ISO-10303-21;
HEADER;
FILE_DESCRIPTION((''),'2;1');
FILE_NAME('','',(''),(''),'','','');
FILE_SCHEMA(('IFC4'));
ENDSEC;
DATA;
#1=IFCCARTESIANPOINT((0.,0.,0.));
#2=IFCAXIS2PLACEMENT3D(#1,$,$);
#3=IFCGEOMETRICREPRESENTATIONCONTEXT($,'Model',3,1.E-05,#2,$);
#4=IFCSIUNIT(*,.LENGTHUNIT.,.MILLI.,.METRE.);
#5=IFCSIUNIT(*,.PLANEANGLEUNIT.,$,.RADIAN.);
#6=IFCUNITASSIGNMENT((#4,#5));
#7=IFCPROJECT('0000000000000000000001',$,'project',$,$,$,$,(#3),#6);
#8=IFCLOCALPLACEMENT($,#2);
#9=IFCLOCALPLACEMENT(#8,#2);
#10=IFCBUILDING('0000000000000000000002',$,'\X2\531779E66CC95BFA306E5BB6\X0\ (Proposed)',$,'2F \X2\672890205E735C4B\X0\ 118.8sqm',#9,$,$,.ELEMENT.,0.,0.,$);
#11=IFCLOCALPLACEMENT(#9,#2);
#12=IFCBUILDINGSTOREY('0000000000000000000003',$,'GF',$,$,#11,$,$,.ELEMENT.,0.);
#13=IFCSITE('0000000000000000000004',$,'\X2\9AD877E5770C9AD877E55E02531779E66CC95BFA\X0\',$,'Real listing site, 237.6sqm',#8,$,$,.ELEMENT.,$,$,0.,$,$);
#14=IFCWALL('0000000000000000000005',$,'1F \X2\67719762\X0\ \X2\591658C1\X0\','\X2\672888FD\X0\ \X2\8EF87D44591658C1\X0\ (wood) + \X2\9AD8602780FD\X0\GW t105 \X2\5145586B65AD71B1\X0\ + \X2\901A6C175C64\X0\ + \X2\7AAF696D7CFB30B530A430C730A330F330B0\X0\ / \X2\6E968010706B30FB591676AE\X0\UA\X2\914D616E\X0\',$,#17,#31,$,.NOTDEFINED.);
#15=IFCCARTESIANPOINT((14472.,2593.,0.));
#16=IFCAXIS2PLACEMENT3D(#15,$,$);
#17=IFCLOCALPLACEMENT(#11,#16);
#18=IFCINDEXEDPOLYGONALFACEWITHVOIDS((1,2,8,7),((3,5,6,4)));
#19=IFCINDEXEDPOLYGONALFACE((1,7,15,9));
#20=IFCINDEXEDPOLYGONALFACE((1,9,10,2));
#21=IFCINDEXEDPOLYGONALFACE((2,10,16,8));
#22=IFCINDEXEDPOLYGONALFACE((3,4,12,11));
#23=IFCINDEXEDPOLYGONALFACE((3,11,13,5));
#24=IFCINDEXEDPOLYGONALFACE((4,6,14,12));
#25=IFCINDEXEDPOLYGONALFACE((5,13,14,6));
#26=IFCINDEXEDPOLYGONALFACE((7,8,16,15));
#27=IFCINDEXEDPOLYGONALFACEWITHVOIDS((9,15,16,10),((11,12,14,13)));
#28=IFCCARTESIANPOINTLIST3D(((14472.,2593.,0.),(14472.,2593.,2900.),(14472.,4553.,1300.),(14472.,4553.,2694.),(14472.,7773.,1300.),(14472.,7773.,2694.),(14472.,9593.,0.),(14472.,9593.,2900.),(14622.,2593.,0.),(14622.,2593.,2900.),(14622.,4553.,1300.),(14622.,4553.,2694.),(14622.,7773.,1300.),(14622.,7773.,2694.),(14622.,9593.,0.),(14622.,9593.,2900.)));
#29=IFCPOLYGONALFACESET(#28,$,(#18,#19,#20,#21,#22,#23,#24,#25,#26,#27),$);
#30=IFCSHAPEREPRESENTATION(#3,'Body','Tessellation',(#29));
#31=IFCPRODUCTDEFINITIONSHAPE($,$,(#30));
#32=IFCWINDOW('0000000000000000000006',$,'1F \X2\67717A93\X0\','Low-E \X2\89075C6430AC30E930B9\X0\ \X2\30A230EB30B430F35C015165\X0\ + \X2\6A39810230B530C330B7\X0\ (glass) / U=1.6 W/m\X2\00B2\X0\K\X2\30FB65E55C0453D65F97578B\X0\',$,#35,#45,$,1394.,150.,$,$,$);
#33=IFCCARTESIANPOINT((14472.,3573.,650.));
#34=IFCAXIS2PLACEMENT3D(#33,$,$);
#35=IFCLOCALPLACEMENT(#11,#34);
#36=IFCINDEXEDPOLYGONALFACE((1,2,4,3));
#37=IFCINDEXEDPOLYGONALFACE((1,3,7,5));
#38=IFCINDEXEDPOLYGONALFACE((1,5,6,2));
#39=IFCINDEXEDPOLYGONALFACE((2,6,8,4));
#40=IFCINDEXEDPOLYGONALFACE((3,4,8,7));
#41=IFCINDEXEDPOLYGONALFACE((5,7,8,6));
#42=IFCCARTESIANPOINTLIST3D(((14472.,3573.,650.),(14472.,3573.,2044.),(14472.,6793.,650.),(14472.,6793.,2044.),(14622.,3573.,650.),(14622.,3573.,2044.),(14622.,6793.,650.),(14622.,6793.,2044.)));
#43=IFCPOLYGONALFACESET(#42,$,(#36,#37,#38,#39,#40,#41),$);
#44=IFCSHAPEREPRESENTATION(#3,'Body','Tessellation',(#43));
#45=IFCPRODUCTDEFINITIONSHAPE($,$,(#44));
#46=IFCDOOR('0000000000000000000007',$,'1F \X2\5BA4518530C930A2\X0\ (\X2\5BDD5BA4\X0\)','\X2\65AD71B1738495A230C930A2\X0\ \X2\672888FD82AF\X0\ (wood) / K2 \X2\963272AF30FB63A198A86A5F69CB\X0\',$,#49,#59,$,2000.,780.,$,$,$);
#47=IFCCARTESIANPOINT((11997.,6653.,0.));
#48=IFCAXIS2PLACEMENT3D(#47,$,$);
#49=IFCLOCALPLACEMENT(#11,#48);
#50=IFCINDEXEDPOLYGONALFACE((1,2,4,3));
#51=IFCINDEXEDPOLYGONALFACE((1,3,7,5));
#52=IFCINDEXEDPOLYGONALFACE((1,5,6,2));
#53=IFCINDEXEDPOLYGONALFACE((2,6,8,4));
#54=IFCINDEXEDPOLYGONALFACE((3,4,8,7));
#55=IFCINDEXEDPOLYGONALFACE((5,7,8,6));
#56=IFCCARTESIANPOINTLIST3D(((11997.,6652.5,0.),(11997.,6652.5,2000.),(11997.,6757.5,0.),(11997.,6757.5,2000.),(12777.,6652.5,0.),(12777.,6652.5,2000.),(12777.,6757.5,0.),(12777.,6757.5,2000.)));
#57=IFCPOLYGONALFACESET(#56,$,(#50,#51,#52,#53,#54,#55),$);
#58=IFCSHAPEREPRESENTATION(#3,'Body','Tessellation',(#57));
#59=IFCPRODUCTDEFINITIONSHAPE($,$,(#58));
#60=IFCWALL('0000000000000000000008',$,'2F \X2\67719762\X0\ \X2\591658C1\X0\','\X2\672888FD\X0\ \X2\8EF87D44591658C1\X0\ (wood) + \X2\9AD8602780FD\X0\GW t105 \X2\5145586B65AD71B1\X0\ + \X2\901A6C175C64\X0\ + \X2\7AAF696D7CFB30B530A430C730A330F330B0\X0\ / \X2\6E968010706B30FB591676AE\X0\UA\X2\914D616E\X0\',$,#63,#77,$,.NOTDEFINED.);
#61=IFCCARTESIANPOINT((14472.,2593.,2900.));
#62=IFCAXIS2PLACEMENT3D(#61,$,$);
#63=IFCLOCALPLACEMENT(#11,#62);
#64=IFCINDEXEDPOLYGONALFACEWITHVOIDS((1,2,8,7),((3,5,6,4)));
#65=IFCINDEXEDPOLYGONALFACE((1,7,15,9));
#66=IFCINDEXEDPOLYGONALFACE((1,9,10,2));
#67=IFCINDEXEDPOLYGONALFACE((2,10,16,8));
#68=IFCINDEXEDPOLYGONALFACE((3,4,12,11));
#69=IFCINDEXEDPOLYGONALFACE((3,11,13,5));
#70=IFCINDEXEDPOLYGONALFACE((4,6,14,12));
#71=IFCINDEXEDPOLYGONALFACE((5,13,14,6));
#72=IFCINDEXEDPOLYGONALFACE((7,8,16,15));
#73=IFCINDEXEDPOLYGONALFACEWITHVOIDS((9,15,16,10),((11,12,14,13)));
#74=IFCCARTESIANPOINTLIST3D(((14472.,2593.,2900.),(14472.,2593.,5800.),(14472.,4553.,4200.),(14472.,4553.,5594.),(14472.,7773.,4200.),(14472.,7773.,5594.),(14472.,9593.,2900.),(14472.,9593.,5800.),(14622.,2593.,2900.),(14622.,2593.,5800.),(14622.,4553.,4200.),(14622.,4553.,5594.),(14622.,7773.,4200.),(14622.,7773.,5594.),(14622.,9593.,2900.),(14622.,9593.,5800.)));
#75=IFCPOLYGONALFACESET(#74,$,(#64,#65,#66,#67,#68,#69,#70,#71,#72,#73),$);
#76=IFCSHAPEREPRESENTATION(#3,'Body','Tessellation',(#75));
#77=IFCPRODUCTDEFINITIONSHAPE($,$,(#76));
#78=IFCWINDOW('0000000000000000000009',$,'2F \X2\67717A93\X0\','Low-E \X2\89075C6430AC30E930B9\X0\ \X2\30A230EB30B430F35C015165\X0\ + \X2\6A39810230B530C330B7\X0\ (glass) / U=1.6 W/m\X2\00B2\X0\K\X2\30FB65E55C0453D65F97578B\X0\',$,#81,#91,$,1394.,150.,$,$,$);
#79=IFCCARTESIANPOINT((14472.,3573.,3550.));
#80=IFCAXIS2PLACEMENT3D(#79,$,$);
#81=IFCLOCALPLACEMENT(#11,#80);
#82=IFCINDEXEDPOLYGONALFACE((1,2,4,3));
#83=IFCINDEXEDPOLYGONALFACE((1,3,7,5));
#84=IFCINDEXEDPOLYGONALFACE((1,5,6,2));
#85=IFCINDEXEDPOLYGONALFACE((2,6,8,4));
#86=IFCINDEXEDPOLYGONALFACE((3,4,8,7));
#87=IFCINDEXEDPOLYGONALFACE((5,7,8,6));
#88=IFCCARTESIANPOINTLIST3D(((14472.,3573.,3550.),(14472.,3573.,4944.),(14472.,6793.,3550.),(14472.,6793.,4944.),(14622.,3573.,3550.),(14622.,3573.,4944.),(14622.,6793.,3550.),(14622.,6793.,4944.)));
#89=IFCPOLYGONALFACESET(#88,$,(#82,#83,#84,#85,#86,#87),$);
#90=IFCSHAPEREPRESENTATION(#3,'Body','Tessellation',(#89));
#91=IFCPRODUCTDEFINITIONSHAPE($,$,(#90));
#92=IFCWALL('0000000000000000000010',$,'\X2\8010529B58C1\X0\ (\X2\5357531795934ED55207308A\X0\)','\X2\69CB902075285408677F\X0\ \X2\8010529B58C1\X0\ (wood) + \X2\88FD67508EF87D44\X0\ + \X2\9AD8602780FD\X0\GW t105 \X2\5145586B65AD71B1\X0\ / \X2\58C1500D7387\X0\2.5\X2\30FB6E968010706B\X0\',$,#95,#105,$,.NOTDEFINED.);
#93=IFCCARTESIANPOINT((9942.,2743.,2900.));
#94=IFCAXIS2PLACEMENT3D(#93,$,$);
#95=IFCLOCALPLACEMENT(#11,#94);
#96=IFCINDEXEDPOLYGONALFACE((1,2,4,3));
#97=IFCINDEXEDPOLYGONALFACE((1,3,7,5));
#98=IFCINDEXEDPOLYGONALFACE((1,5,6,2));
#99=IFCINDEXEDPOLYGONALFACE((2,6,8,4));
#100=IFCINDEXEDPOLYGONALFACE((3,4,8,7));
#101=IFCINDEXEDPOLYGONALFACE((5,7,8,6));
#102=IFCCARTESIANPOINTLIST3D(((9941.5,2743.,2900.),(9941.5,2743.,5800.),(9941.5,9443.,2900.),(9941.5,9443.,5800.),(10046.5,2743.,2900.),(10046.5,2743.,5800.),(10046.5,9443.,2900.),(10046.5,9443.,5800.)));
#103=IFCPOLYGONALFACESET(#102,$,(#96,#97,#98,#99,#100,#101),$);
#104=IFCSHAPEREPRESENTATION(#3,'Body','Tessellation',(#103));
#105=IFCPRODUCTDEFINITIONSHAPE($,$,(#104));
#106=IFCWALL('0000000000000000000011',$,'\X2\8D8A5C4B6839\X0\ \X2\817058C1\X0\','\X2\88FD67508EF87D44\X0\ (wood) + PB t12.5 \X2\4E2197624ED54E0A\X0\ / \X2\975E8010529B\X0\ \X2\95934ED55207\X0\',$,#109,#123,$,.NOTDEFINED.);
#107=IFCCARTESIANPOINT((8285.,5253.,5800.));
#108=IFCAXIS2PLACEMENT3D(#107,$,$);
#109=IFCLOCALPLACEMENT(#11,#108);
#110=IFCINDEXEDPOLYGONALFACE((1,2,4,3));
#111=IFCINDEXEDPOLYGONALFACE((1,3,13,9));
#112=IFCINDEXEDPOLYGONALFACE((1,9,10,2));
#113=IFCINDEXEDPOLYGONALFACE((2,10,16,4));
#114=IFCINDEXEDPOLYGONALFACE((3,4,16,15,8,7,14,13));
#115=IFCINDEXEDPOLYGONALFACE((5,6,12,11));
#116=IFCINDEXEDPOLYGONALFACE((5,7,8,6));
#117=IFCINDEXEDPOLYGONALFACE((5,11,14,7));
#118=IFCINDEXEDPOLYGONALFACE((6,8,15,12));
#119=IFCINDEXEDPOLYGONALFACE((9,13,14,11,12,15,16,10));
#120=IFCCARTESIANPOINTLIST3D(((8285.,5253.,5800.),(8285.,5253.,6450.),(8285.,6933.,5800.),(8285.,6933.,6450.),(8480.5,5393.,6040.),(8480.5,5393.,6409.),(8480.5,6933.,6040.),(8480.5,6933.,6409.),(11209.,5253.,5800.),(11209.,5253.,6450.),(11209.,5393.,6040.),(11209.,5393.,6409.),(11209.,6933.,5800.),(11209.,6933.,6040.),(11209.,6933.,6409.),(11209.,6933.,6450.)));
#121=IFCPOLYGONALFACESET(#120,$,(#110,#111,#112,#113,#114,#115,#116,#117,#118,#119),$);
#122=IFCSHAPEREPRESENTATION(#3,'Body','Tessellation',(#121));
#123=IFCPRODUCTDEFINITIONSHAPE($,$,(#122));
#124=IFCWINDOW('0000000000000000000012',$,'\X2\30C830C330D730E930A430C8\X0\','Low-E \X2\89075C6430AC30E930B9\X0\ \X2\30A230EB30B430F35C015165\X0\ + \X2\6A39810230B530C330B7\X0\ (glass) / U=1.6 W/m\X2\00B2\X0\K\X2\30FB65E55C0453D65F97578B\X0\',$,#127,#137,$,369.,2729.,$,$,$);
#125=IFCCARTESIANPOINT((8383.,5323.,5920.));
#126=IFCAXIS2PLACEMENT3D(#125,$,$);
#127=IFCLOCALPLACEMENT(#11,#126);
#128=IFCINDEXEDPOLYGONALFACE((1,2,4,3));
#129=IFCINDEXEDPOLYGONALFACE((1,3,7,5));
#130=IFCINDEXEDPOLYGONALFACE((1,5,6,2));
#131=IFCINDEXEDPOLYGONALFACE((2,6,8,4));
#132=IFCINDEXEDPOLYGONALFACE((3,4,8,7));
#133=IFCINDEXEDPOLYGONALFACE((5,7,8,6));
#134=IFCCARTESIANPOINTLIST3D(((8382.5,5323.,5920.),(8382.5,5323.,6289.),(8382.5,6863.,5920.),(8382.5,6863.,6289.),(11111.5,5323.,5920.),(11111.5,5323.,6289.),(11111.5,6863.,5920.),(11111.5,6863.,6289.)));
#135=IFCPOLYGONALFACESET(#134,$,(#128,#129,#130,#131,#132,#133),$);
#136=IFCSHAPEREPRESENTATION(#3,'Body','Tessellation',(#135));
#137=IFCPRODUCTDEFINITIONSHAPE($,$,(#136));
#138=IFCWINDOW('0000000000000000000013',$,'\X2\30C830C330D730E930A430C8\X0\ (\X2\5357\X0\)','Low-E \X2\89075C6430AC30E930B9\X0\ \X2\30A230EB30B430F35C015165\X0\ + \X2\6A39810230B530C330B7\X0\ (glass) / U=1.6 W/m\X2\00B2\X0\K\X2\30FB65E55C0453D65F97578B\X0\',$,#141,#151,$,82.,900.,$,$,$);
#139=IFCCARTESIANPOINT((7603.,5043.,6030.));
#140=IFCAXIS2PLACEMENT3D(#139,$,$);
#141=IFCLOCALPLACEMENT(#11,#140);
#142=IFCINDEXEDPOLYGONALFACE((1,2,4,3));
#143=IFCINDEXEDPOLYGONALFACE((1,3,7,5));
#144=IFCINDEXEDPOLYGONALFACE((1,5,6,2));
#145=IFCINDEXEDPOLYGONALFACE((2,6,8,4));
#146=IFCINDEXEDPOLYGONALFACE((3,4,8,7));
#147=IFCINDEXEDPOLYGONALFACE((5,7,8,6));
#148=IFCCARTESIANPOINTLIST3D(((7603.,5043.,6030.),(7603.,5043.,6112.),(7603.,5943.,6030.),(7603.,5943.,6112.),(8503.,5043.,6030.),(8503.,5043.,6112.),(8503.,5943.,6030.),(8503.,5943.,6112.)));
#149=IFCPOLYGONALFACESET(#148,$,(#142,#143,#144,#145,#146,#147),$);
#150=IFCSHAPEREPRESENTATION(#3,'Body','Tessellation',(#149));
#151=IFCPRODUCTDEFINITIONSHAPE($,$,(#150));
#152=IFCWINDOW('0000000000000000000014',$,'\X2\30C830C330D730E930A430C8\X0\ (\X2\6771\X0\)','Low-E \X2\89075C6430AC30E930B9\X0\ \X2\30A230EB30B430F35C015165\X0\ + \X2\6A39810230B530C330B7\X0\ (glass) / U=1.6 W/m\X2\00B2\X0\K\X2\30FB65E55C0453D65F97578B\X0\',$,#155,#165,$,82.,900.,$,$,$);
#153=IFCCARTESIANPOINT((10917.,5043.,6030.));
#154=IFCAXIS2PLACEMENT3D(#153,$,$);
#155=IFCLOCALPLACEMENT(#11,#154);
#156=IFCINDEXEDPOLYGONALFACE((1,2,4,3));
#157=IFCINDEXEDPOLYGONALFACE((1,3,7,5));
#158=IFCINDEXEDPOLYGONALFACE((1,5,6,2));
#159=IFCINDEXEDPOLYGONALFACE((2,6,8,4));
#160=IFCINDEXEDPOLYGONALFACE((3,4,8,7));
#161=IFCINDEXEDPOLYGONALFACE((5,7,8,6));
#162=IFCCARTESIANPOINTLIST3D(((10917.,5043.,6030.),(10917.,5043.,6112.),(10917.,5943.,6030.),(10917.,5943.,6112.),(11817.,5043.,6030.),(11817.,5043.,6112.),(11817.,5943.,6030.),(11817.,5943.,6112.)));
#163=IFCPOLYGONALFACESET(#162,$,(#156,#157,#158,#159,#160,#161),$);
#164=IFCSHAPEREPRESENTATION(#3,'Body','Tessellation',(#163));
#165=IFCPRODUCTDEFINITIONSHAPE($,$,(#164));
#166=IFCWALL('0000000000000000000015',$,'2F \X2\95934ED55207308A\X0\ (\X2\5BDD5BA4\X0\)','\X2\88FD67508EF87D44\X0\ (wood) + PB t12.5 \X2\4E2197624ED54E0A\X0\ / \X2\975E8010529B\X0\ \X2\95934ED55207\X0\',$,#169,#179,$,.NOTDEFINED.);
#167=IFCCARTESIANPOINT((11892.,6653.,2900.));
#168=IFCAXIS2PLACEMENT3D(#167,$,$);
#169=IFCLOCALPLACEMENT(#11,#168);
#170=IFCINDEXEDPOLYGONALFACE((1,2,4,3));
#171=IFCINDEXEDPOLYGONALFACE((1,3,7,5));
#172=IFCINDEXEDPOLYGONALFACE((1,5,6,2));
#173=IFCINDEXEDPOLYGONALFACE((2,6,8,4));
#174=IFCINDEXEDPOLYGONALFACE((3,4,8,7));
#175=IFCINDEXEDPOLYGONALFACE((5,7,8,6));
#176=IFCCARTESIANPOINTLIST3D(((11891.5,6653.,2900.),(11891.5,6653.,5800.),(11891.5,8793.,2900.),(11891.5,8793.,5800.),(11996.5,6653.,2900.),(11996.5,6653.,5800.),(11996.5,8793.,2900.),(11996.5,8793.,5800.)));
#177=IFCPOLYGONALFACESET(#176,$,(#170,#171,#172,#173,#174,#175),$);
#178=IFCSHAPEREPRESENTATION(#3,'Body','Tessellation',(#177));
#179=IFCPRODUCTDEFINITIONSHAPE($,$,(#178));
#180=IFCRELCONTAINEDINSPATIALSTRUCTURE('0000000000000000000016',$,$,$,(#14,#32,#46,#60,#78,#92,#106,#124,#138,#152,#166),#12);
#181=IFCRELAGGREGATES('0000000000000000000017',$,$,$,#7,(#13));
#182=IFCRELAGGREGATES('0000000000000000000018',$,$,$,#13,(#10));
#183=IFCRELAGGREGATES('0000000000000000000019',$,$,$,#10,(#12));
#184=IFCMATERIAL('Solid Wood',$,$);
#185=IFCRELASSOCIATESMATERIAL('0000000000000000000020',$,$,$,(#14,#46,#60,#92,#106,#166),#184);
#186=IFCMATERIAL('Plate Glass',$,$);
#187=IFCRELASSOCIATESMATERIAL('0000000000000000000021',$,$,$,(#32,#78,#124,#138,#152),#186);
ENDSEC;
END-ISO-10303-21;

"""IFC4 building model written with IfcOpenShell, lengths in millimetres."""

from ifc_helpers import new_model, si_unit, frame, frame_2d, origin, place, context, project, spatial, rectangle, extrude, material, element, fill, save


model = new_model("IFC4")

# Units and contexts
model_context = context("Model", 3, precision=1e-05, world=origin())
ifc_project = project(units=[si_unit("LENGTHUNIT", "METRE", prefix="MILLI"), si_unit("PLANEANGLEUNIT", "RADIAN")], contexts=[model_context])

# Site, building, storey
site_placement = place(None, origin())
site = spatial("IfcSite", under=ifc_project, at=site_placement, Name="高知県高知市北秦泉寺", ObjectType="Real listing site, 237.6sqm", CompositionType="ELEMENT", RefElevation=0.0)
building_placement = place(site_placement, origin())
building = spatial("IfcBuilding", under=site, at=building_placement, Name="北秦泉寺の家 (Proposed)", ObjectType="2F 木造平屋 118.8sqm", CompositionType="ELEMENT", ElevationOfRefHeight=0.0, ElevationOfTerrain=0.0)
storey_placement = place(building_placement, origin())
storey = spatial("IfcBuildingStorey", under=building, at=storey_placement, Name="GF", CompositionType="ELEMENT", Elevation=0.0)

# Wall, opening, window
ifc_material_1 = material(Name="Solid Wood")
wall_1_placement = place(storey_placement, frame((14472.0, 2593.0, 0.0)))
wall_1 = element("IfcWall", 1, at=wall_1_placement, inside=storey, material=ifc_material_1, Name="1F 東面 外壁", Description="木製 軸組外壁 (wood) + 高性能GW t105 充填断熱 + 通気層 + 窯業系サイディング / 準耐火・外皮UA配慮", PredefinedType="NOTDEFINED", context=model_context, shape_type="SweptSolid", body=[
    extrude(rectangle(XDim=150.0, YDim=7000.0, at=frame_2d((75.0, 3500.0))), frame((14472.0, 2593.0, 0.0)), (0.0, 0.0, 1.0), 2900.0),
])
opening_1_placement = place(storey_placement, frame((14472.0, 3573.0, 650.0)))
opening_1 = element("IfcOpeningElement", 2, at=opening_1_placement, cuts=wall_1, PredefinedType="NOTDEFINED", context=model_context, shape_type="SweptSolid", body=[
    extrude(rectangle(XDim=150.0, YDim=3220.0, at=frame_2d((75.0, 1610.0))), frame((14472.0, 3573.0, 650.0)), (0.0, 0.0, 1.0), 1394.0),
])
ifc_material_2 = material(Name="Plate Glass")
window_1_placement = place(storey_placement, frame((14472.0, 3573.0, 650.0)))
window_1 = element("IfcWindow", 3, at=window_1_placement, inside=storey, material=ifc_material_2, Name="1F 東窓", Description="Low-E 複層ガラス アルゴン封入 + 樹脂サッシ (glass) / U=1.6 W/m²K・日射取得型", OverallHeight=1394.0, OverallWidth=150.0, context=model_context, shape_type="SweptSolid", body=[
    extrude(rectangle(XDim=150.0, YDim=3220.0, at=frame_2d((75.0, 1610.0))), frame((14472.0, 3573.0, 650.0)), (0.0, 0.0, 1.0), 1394.0),
])
fill(opening_1, window_1)

# Door
door_1_placement = place(storey_placement, frame((11997.0, 6653.0, 0.0)))
element("IfcDoor", 4, at=door_1_placement, inside=storey, material=ifc_material_1, Name="1F 室内ドア (寝室)", Description="断熱玄関ドア 木製芯 (wood) / K2 防犯・採風機構", OverallHeight=2000.0, OverallWidth=780.0, context=model_context, shape_type="SweptSolid", body=[
    extrude(rectangle(XDim=780.0, YDim=105.0, at=frame_2d((390.0, 52.0))), frame((11997.0, 6653.0, 0.0)), (0.0, 0.0, 1.0), 2000.0),
])

# Wall, opening, window
wall_2_placement = place(storey_placement, frame((14472.0, 2593.0, 2900.0)))
wall_2 = element("IfcWall", 5, at=wall_2_placement, inside=storey, material=ifc_material_1, Name="2F 東面 外壁", Description="木製 軸組外壁 (wood) + 高性能GW t105 充填断熱 + 通気層 + 窯業系サイディング / 準耐火・外皮UA配慮", PredefinedType="NOTDEFINED", context=model_context, shape_type="SweptSolid", body=[
    extrude(rectangle(XDim=150.0, YDim=7000.0, at=frame_2d((75.0, 3500.0))), frame((14472.0, 2593.0, 2900.0)), (0.0, 0.0, 1.0), 2900.0),
])
opening_2_placement = place(storey_placement, frame((14472.0, 3573.0, 3550.0)))
opening_2 = element("IfcOpeningElement", 6, at=opening_2_placement, cuts=wall_2, PredefinedType="NOTDEFINED", context=model_context, shape_type="SweptSolid", body=[
    extrude(rectangle(XDim=150.0, YDim=3220.0, at=frame_2d((75.0, 1610.0))), frame((14472.0, 3573.0, 3550.0)), (0.0, 0.0, 1.0), 1394.0),
])
window_2_placement = place(storey_placement, frame((14472.0, 3573.0, 3550.0)))
window_2 = element("IfcWindow", 7, at=window_2_placement, inside=storey, material=ifc_material_2, Name="2F 東窓", Description="Low-E 複層ガラス アルゴン封入 + 樹脂サッシ (glass) / U=1.6 W/m²K・日射取得型", OverallHeight=1394.0, OverallWidth=150.0, context=model_context, shape_type="SweptSolid", body=[
    extrude(rectangle(XDim=150.0, YDim=3220.0, at=frame_2d((75.0, 1610.0))), frame((14472.0, 3573.0, 3550.0)), (0.0, 0.0, 1.0), 1394.0),
])
fill(opening_2, window_2)

# Wall
wall_3_placement = place(storey_placement, frame((9942.0, 2743.0, 2900.0)))
element("IfcWall", 8, at=wall_3_placement, inside=storey, material=ifc_material_1, Name="耐力壁 (南北間仕切り)", Description="構造用合板 耐力壁 (wood) + 製材軸組 + 高性能GW t105 充填断熱 / 壁倍率2.5・準耐火", PredefinedType="NOTDEFINED", context=model_context, shape_type="SweptSolid", body=[
    extrude(rectangle(XDim=105.0, YDim=6700.0, at=frame_2d((52.0, 3350.0))), frame((9942.0, 2743.0, 2900.0)), (0.0, 0.0, 1.0), 2900.0),
])

# Wall, openings, windows
wall_4_placement = place(storey_placement, frame((8285.0, 5253.0, 5800.0)))
wall_4 = element("IfcWall", 9, at=wall_4_placement, inside=storey, material=ifc_material_1, Name="越屋根 腰壁", Description="製材軸組 (wood) + PB t12.5 両面仕上 / 非耐力 間仕切", PredefinedType="NOTDEFINED", context=model_context, shape_type="SweptSolid", body=[
    extrude(rectangle(XDim=2924.0, YDim=1680.0, at=frame_2d((1462.0, 840.0))), frame((8285.0, 5253.0, 5800.0)), (0.0, 0.0, 1.0), 650.0),
])
opening_3_placement = place(storey_placement, frame((8383.0, 5323.0, 5920.0)))
opening_3 = element("IfcOpeningElement", 10, at=opening_3_placement, cuts=wall_4, PredefinedType="NOTDEFINED", context=model_context, shape_type="SweptSolid", body=[
    extrude(rectangle(XDim=2729.0, YDim=1540.0, at=frame_2d((1364.0, 770.0))), frame((8383.0, 5323.0, 5920.0)), (0.0, 0.0, 1.0), 369.0),
])
opening_4_placement = place(storey_placement, frame((7603.0, 5043.0, 6030.0)))
opening_4 = element("IfcOpeningElement", 11, at=opening_4_placement, cuts=wall_4, PredefinedType="NOTDEFINED", context=model_context, shape_type="SweptSolid", body=[
    extrude(rectangle(XDim=900.0, YDim=900.0, at=frame_2d((450.0, 450.0))), frame((7603.0, 5043.0, 6030.0)), (0.0, 0.0, 1.0), 82.0),
])
opening_5_placement = place(storey_placement, frame((10917.0, 5043.0, 6030.0)))
opening_5 = element("IfcOpeningElement", 12, at=opening_5_placement, cuts=wall_4, PredefinedType="NOTDEFINED", context=model_context, shape_type="SweptSolid", body=[
    extrude(rectangle(XDim=900.0, YDim=900.0, at=frame_2d((450.0, 450.0))), frame((10917.0, 5043.0, 6030.0)), (0.0, 0.0, 1.0), 82.0),
])
window_3_placement = place(storey_placement, frame((8383.0, 5323.0, 5920.0)))
window_3 = element("IfcWindow", 13, at=window_3_placement, inside=storey, material=ifc_material_2, Name="トップライト", Description="Low-E 複層ガラス アルゴン封入 + 樹脂サッシ (glass) / U=1.6 W/m²K・日射取得型", OverallHeight=369.0, OverallWidth=2729.0, context=model_context, shape_type="SweptSolid", body=[
    extrude(rectangle(XDim=2729.0, YDim=1540.0, at=frame_2d((1364.0, 770.0))), frame((8383.0, 5323.0, 5920.0)), (0.0, 0.0, 1.0), 369.0),
])
fill(opening_3, window_3)
window_4_placement = place(storey_placement, frame((7603.0, 5043.0, 6030.0)))
window_4 = element("IfcWindow", 14, at=window_4_placement, inside=storey, material=ifc_material_2, Name="トップライト (南)", Description="Low-E 複層ガラス アルゴン封入 + 樹脂サッシ (glass) / U=1.6 W/m²K・日射取得型", OverallHeight=82.0, OverallWidth=900.0, context=model_context, shape_type="SweptSolid", body=[
    extrude(rectangle(XDim=900.0, YDim=900.0, at=frame_2d((450.0, 450.0))), frame((7603.0, 5043.0, 6030.0)), (0.0, 0.0, 1.0), 82.0),
])
fill(opening_4, window_4)
window_5_placement = place(storey_placement, frame((10917.0, 5043.0, 6030.0)))
window_5 = element("IfcWindow", 15, at=window_5_placement, inside=storey, material=ifc_material_2, Name="トップライト (東)", Description="Low-E 複層ガラス アルゴン封入 + 樹脂サッシ (glass) / U=1.6 W/m²K・日射取得型", OverallHeight=82.0, OverallWidth=900.0, context=model_context, shape_type="SweptSolid", body=[
    extrude(rectangle(XDim=900.0, YDim=900.0, at=frame_2d((450.0, 450.0))), frame((10917.0, 5043.0, 6030.0)), (0.0, 0.0, 1.0), 82.0),
])
fill(opening_5, window_5)

# Wall
wall_5_placement = place(storey_placement, frame((11892.0, 6653.0, 2900.0)))
element("IfcWall", 16, at=wall_5_placement, inside=storey, material=ifc_material_1, Name="2F 間仕切り (寝室)", Description="製材軸組 (wood) + PB t12.5 両面仕上 / 非耐力 間仕切", PredefinedType="NOTDEFINED", context=model_context, shape_type="SweptSolid", body=[
    extrude(rectangle(XDim=105.0, YDim=2140.0, at=frame_2d((52.0, 1070.0))), frame((11892.0, 6653.0, 2900.0)), (0.0, 0.0, 1.0), 2900.0),
])

save(model, "model.ifc")
